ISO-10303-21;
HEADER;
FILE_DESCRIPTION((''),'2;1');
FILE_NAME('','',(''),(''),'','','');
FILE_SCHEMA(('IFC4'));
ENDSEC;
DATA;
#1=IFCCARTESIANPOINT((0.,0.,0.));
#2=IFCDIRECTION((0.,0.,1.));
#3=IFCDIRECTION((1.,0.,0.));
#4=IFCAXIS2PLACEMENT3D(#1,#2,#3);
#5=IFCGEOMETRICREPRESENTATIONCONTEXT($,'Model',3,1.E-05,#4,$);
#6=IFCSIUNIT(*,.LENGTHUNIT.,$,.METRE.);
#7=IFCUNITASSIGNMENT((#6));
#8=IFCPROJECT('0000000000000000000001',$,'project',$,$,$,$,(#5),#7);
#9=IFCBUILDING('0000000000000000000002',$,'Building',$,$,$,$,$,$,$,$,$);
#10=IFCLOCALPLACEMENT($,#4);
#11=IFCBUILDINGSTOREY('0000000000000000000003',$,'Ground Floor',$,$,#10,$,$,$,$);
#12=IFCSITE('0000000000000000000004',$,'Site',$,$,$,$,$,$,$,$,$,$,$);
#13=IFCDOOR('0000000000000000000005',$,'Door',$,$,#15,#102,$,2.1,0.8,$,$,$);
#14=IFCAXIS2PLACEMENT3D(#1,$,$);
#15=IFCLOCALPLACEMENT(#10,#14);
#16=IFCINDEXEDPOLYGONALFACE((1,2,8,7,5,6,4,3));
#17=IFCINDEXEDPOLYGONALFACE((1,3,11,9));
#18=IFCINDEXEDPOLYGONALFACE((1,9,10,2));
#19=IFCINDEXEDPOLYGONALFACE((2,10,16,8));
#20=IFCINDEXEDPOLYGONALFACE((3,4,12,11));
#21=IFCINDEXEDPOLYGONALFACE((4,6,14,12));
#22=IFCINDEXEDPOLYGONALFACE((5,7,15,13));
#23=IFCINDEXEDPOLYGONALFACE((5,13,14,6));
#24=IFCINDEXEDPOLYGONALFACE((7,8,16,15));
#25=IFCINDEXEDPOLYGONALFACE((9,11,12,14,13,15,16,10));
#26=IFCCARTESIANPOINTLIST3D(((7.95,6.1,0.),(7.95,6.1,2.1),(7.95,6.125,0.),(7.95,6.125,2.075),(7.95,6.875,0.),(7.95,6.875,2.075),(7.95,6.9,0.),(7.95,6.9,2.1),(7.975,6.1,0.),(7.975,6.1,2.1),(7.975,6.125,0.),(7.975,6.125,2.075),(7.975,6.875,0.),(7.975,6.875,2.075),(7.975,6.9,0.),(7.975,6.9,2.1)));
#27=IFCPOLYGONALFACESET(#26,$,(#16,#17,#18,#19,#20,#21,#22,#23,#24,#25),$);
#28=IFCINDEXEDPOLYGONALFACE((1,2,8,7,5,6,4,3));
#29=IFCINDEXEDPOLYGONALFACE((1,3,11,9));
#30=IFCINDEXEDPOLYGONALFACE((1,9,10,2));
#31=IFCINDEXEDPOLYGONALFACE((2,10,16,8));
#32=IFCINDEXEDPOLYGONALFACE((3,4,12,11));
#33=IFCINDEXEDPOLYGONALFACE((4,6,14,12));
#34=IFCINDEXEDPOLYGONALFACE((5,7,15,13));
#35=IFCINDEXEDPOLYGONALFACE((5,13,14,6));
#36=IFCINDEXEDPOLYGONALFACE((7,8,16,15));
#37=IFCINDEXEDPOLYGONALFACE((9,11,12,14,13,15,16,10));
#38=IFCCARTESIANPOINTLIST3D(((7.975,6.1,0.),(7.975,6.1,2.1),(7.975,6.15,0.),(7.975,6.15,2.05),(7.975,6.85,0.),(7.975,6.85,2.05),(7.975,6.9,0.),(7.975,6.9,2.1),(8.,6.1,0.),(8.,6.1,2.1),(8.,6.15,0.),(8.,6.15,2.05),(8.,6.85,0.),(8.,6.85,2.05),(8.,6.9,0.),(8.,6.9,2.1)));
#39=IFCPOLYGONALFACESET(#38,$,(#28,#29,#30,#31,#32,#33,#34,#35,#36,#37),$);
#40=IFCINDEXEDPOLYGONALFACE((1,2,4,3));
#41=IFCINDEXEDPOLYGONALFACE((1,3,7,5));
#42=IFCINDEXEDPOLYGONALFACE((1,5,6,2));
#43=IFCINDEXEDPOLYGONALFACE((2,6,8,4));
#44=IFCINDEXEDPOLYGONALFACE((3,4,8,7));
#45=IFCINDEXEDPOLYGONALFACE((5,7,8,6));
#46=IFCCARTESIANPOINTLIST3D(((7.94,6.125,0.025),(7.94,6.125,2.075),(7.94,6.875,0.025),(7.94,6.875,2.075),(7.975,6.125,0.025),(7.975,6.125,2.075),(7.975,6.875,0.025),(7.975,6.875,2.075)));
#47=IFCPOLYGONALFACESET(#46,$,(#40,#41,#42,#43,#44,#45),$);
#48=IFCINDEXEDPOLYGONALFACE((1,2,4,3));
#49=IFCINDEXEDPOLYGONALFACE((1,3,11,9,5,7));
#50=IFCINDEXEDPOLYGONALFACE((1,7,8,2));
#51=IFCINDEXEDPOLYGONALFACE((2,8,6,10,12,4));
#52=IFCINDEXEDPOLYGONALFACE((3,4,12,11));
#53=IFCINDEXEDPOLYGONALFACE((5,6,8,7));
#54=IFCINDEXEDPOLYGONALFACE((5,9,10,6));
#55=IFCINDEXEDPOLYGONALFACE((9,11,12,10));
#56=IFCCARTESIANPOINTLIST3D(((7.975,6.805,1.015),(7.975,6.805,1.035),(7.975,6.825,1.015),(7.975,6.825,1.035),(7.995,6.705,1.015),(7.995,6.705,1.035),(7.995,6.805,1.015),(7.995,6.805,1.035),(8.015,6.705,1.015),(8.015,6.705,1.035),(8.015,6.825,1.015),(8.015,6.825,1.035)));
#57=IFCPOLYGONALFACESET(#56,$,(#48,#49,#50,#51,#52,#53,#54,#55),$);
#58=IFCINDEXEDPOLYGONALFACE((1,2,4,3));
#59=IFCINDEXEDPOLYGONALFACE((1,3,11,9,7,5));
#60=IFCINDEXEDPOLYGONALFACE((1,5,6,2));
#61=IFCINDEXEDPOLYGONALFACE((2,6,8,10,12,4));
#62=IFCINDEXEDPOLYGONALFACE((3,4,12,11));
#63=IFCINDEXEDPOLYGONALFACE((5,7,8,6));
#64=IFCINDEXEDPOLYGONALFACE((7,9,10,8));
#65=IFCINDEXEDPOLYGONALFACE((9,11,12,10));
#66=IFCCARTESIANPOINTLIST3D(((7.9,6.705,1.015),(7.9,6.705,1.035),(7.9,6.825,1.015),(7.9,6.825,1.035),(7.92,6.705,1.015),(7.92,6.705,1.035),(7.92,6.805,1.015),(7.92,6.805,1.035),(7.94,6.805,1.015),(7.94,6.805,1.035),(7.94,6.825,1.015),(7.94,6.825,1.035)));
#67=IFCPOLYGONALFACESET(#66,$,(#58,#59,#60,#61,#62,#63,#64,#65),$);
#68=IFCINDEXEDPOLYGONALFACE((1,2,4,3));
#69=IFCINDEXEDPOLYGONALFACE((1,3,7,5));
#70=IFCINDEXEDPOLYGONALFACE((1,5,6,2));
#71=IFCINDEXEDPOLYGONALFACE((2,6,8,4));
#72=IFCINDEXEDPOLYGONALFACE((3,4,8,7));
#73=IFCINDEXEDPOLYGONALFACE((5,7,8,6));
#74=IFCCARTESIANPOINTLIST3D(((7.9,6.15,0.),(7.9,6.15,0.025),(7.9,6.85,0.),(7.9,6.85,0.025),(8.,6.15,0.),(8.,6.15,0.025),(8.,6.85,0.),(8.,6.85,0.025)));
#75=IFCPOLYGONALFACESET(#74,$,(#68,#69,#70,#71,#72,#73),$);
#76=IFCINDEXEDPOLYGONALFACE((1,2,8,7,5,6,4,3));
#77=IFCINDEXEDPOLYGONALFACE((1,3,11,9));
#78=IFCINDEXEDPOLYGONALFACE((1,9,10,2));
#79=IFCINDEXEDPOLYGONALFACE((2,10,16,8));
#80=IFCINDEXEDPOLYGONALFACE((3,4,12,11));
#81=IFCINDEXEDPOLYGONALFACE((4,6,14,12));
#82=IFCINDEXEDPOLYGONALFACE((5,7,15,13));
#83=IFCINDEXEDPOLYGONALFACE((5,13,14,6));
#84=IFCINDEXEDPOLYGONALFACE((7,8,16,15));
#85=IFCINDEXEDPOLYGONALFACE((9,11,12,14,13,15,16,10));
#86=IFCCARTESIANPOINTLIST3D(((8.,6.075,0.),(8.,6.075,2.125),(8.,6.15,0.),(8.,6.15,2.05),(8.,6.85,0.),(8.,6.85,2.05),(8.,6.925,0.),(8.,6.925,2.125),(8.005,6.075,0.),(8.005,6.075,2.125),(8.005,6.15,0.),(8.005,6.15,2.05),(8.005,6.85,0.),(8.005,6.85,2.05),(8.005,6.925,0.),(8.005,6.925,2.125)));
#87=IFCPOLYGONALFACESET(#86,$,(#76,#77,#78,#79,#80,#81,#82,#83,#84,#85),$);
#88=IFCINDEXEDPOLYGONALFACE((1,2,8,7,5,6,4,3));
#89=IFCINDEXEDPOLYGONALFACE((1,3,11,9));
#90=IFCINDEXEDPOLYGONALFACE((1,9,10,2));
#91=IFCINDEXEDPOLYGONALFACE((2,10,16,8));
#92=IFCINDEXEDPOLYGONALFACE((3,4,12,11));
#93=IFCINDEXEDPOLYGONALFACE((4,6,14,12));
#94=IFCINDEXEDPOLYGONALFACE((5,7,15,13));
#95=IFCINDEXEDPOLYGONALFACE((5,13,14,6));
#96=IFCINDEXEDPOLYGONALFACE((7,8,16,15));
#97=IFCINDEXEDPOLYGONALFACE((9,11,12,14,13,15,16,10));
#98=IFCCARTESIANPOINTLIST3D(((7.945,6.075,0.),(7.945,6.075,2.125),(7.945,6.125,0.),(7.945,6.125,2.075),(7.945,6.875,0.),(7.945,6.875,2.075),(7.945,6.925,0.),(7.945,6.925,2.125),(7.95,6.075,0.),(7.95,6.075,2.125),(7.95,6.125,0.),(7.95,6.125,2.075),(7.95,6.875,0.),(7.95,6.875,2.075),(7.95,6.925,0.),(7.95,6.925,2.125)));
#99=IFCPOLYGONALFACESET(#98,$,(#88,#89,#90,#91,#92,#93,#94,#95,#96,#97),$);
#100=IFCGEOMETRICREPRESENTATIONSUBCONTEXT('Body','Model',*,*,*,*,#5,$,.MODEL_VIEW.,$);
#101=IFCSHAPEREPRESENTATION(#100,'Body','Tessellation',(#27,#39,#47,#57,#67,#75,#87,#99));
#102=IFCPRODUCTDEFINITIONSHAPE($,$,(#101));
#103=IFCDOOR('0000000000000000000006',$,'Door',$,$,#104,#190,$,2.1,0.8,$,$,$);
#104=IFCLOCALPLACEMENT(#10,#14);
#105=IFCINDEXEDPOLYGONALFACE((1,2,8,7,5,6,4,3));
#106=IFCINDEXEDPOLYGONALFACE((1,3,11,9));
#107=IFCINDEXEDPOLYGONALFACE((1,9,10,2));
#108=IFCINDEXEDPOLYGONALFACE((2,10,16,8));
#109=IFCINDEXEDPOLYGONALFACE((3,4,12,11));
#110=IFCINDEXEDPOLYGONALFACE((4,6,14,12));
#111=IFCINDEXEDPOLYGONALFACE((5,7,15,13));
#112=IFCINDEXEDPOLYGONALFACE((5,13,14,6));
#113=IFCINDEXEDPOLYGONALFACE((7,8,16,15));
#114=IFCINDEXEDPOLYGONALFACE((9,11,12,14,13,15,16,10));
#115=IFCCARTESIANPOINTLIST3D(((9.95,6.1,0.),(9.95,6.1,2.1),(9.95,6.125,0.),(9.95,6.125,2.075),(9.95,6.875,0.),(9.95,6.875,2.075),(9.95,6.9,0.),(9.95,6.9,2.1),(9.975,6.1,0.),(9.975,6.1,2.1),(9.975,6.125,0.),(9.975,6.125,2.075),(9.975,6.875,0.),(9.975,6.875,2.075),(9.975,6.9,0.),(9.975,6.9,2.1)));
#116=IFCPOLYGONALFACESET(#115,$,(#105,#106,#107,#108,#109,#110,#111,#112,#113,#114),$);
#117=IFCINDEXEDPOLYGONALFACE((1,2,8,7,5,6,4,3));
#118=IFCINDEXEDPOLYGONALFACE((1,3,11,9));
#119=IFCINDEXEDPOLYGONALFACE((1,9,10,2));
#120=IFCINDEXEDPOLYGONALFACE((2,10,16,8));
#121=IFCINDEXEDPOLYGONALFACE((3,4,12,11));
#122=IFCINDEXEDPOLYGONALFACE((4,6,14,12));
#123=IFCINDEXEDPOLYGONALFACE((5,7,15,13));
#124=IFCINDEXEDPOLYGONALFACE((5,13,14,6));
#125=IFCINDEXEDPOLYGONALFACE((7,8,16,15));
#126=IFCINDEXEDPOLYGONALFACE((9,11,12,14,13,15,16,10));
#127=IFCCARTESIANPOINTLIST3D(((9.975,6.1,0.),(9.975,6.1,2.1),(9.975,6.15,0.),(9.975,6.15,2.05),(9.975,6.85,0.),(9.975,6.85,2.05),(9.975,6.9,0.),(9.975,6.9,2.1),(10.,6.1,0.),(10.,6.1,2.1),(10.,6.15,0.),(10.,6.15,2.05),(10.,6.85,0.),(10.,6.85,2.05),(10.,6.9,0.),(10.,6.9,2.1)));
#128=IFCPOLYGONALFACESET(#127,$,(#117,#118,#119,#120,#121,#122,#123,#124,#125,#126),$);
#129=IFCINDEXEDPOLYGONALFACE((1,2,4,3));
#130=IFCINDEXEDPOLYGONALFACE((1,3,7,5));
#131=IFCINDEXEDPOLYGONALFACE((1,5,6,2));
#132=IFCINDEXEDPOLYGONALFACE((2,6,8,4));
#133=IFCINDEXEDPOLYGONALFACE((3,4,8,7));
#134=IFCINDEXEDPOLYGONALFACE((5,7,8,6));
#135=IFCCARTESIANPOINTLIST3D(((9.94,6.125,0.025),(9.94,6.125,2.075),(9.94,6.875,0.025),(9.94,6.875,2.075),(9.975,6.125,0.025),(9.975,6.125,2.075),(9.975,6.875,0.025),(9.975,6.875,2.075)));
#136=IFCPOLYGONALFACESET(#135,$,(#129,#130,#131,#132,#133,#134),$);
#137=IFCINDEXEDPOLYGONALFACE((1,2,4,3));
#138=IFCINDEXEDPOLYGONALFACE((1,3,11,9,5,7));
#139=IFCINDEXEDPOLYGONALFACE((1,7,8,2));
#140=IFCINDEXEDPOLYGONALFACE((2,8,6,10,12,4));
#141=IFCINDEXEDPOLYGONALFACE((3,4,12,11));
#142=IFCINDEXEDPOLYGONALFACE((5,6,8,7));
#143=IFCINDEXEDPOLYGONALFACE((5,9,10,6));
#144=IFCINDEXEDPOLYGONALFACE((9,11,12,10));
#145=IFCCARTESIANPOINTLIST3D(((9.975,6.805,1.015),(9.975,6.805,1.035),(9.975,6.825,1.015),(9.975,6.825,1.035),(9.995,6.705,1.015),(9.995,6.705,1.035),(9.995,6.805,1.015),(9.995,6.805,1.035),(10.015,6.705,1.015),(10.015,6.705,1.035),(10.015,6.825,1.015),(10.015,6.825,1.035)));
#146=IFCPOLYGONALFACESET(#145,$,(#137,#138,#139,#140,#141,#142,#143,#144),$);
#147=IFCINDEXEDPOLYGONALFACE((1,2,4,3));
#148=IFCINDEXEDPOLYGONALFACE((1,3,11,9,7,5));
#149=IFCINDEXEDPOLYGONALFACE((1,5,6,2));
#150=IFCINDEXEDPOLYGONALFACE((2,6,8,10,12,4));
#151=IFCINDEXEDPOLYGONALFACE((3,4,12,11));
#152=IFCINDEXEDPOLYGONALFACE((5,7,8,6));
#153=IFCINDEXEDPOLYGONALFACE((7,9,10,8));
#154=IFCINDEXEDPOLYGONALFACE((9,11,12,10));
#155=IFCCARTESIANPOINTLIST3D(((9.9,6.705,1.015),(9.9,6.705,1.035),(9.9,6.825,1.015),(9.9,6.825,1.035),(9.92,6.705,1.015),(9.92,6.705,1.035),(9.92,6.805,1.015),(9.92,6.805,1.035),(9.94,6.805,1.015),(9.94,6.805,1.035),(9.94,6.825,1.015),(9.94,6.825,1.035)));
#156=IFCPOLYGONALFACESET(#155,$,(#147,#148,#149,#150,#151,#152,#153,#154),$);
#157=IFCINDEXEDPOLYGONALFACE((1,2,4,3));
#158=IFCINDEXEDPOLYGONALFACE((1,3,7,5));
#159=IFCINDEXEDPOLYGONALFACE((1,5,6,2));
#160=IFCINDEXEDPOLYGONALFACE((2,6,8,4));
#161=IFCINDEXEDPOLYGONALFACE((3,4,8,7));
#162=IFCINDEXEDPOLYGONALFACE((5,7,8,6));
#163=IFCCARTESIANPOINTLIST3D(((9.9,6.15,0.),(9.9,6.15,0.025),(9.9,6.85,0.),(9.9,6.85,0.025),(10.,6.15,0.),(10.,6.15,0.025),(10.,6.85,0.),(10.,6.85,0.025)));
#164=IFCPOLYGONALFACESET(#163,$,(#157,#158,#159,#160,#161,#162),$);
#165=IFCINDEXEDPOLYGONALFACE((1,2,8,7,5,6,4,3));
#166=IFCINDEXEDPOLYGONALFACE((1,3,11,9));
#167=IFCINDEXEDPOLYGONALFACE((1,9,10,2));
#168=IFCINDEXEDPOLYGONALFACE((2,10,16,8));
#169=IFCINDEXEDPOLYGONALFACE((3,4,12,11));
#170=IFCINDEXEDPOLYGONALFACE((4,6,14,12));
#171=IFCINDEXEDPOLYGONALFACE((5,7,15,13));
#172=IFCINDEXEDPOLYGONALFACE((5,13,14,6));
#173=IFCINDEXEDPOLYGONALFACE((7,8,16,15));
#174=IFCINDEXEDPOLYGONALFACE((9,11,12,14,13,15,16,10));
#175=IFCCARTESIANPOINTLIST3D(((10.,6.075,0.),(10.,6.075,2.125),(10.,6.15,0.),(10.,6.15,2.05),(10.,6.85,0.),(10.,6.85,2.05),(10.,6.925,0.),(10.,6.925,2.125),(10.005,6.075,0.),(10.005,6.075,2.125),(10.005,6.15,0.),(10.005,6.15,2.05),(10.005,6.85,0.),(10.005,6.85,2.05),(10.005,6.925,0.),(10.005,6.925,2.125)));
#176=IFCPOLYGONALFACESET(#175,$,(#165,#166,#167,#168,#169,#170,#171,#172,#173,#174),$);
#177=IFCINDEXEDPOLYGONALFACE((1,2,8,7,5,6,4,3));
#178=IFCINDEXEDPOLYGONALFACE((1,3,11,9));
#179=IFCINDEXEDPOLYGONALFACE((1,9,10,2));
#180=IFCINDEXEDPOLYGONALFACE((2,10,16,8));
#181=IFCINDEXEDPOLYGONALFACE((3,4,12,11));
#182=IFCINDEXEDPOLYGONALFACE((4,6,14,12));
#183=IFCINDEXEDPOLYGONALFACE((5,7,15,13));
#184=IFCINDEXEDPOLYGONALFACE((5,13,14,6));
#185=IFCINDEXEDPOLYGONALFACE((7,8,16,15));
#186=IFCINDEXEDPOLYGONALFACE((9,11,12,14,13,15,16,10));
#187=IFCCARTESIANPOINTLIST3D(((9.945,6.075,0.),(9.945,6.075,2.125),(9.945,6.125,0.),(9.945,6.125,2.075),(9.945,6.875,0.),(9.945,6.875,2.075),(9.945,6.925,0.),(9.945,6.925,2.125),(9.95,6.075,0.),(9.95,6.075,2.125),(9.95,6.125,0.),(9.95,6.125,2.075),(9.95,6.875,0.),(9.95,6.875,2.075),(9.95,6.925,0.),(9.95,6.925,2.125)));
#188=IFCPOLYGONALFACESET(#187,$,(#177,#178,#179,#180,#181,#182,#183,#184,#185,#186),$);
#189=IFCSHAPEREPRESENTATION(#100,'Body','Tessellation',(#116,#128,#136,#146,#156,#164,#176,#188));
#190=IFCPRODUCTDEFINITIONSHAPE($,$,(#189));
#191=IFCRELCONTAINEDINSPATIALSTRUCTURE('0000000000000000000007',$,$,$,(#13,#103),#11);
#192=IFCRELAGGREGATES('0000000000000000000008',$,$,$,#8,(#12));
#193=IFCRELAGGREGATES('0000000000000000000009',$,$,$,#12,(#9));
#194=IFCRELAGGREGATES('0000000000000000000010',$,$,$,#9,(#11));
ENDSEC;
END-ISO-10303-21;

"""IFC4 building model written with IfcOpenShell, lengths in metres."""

from ifc_helpers import new_model, si_unit, frame, origin_with_axes, place, context, subcontext, project, spatial, line, indexed_curve, outline, extrude, element, save


model = new_model("IFC4")

# Units and contexts
model_context = context("Model", 3, precision=1e-05, world=origin_with_axes())
body_context = subcontext(model_context, "Body", "Model", "MODEL_VIEW")
ifc_project = project(units=[si_unit("LENGTHUNIT", "METRE")], contexts=[model_context])

# Site, building, storey
site = spatial("IfcSite", under=ifc_project, Name="Site")
building = spatial("IfcBuilding", under=site, Name="Building")
storey_placement = place(None, origin_with_axes())
storey = spatial("IfcBuildingStorey", under=building, at=storey_placement, Name="Ground Floor")

# Doors
door_1_placement = place(storey_placement, frame((8.0, 6.1, 0.0), z_axis=(0.0, 0.0, 1.0), x_axis=(0.0, 1.0, 0.0)))
element("IfcDoor", 1, at=door_1_placement, inside=storey, Name="Door", OverallHeight=2.1, OverallWidth=0.8, context=body_context, shape_type="SweptSolid", body=[
    extrude(outline(indexed_curve([(0.0, 0.0), (0.0, 2.1), (0.8, 2.1), (0.8, 0.0), (0.775, 0.0), (0.775, 2.075), (0.025, 2.075), (0.025, 0.0)], segments=[line(1, 2, 3, 4, 5, 6, 7, 8, 1)])), frame((0.0, 0.025, 0.0), z_axis=(0.0, -1.0, 0.0), x_axis=(1.0, 0.0, 0.0)), (0.0, 0.0, -1.0), 0.025),
    extrude(outline(indexed_curve([(0.0, 0.0), (0.0, 2.1), (0.8, 2.1), (0.8, 0.0), (0.75, 0.0), (0.75, 2.05), (0.05, 2.05), (0.05, 0.0)], segments=[line(1, 2, 3, 4, 5, 6, 7, 8, 1)])), frame((0.0, 0.0, 0.0), z_axis=(0.0, -1.0, 0.0), x_axis=(1.0, 0.0, 0.0)), (0.0, 0.0, -1.0), 0.025),
    extrude(outline(indexed_curve([(0.0, 0.0), (0.75, 0.0), (0.75, 0.035), (0.0, 0.035)], segments=[line(1, 2, 3, 4, 1)])), frame((0.025, 0.025, 0.025), z_axis=(0.0, 0.0, 1.0), x_axis=(1.0, 0.0, 0.0)), (0.0, 0.0, 1.0), 2.05),
    extrude(outline(indexed_curve([(0.0, 0.0), (0.0, -0.04), (-0.12, -0.04), (-0.12, -0.02), (-0.02, -0.02), (-0.02, 0.0)], segments=[line(1, 2, 3, 4, 5, 6, 1)])), frame((0.725, 0.025, 1.015), z_axis=(0.0, 0.0, 1.0), x_axis=(1.0, 0.0, 0.0)), (0.0, 0.0, 1.0), 0.02),
    extrude(outline(indexed_curve([(0.0, 0.0), (0.0, 0.04), (-0.12, 0.04), (-0.12, 0.02), (-0.02, 0.02), (-0.02, 0.0)], segments=[line(1, 2, 3, 4, 5, 6, 1)])), frame((0.725, 0.06, 1.015), z_axis=(0.0, 0.0, 1.0), x_axis=(1.0, 0.0, 0.0)), (0.0, 0.0, 1.0), 0.02),
    extrude(outline(indexed_curve([(0.0, 0.0), (0.7, 0.0), (0.7, 0.1), (0.0, 0.1)], segments=[line(1, 2, 3, 4, 1)])), frame((0.05, 0.0, 0.0), z_axis=(0.0, 0.0, 1.0), x_axis=(1.0, 0.0, 0.0)), (0.0, 0.0, 1.0), 0.025),
    extrude(outline(indexed_curve([(0.0, 0.0), (0.0, 2.125), (0.85, 2.125), (0.85, 0.0), (0.775, 0.0), (0.775, 2.05), (0.075, 2.05), (0.075, 0.0)], segments=[line(1, 2, 3, 4, 5, 6, 7, 8, 1)])), frame((-0.025, -0.005, 0.0), z_axis=(0.0, -1.0, 0.0), x_axis=(1.0, 0.0, 0.0)), (0.0, 0.0, -1.0), 0.005),
    extrude(outline(indexed_curve([(0.0, 0.0), (0.0, 2.125), (0.85, 2.125), (0.85, 0.0), (0.8, 0.0), (0.8, 2.075), (0.05, 2.075), (0.05, 0.0)], segments=[line(1, 2, 3, 4, 5, 6, 7, 8, 1)])), frame((-0.025, 0.05, 0.0), z_axis=(0.0, -1.0, 0.0), x_axis=(1.0, 0.0, 0.0)), (0.0, 0.0, -1.0), 0.005),
])
door_2_placement = place(storey_placement, frame((10.0, 6.1, 0.0), z_axis=(0.0, 0.0, 1.0), x_axis=(0.0, 1.0, 0.0)))
element("IfcDoor", 2, at=door_2_placement, inside=storey, Name="Door", OverallHeight=2.1, OverallWidth=0.8, context=body_context, shape_type="SweptSolid", body=[
    extrude(outline(indexed_curve([(0.0, 0.0), (0.0, 2.1), (0.8, 2.1), (0.8, 0.0), (0.775, 0.0), (0.775, 2.075), (0.025, 2.075), (0.025, 0.0)], segments=[line(1, 2, 3, 4, 5, 6, 7, 8, 1)])), frame((0.0, 0.025, 0.0), z_axis=(0.0, -1.0, 0.0), x_axis=(1.0, 0.0, 0.0)), (0.0, 0.0, -1.0), 0.025),
    extrude(outline(indexed_curve([(0.0, 0.0), (0.0, 2.1), (0.8, 2.1), (0.8, 0.0), (0.75, 0.0), (0.75, 2.05), (0.05, 2.05), (0.05, 0.0)], segments=[line(1, 2, 3, 4, 5, 6, 7, 8, 1)])), frame((0.0, 0.0, 0.0), z_axis=(0.0, -1.0, 0.0), x_axis=(1.0, 0.0, 0.0)), (0.0, 0.0, -1.0), 0.025),
    extrude(outline(indexed_curve([(0.0, 0.0), (0.75, 0.0), (0.75, 0.035), (0.0, 0.035)], segments=[line(1, 2, 3, 4, 1)])), frame((0.025, 0.025, 0.025), z_axis=(0.0, 0.0, 1.0), x_axis=(1.0, 0.0, 0.0)), (0.0, 0.0, 1.0), 2.05),
    extrude(outline(indexed_curve([(0.0, 0.0), (0.0, -0.04), (-0.12, -0.04), (-0.12, -0.02), (-0.02, -0.02), (-0.02, 0.0)], segments=[line(1, 2, 3, 4, 5, 6, 1)])), frame((0.725, 0.025, 1.015), z_axis=(0.0, 0.0, 1.0), x_axis=(1.0, 0.0, 0.0)), (0.0, 0.0, 1.0), 0.02),
    extrude(outline(indexed_curve([(0.0, 0.0), (0.0, 0.04), (-0.12, 0.04), (-0.12, 0.02), (-0.02, 0.02), (-0.02, 0.0)], segments=[line(1, 2, 3, 4, 5, 6, 1)])), frame((0.725, 0.06, 1.015), z_axis=(0.0, 0.0, 1.0), x_axis=(1.0, 0.0, 0.0)), (0.0, 0.0, 1.0), 0.02),
    extrude(outline(indexed_curve([(0.0, 0.0), (0.7, 0.0), (0.7, 0.1), (0.0, 0.1)], segments=[line(1, 2, 3, 4, 1)])), frame((0.05, 0.0, 0.0), z_axis=(0.0, 0.0, 1.0), x_axis=(1.0, 0.0, 0.0)), (0.0, 0.0, 1.0), 0.025),
    extrude(outline(indexed_curve([(0.0, 0.0), (0.0, 2.125), (0.85, 2.125), (0.85, 0.0), (0.775, 0.0), (0.775, 2.05), (0.075, 2.05), (0.075, 0.0)], segments=[line(1, 2, 3, 4, 5, 6, 7, 8, 1)])), frame((-0.025, -0.005, 0.0), z_axis=(0.0, -1.0, 0.0), x_axis=(1.0, 0.0, 0.0)), (0.0, 0.0, -1.0), 0.005),
    extrude(outline(indexed_curve([(0.0, 0.0), (0.0, 2.125), (0.85, 2.125), (0.85, 0.0), (0.8, 0.0), (0.8, 2.075), (0.05, 2.075), (0.05, 0.0)], segments=[line(1, 2, 3, 4, 5, 6, 7, 8, 1)])), frame((-0.025, 0.05, 0.0), z_axis=(0.0, -1.0, 0.0), x_axis=(1.0, 0.0, 0.0)), (0.0, 0.0, -1.0), 0.005),
])

save(model, "model.ifc")
